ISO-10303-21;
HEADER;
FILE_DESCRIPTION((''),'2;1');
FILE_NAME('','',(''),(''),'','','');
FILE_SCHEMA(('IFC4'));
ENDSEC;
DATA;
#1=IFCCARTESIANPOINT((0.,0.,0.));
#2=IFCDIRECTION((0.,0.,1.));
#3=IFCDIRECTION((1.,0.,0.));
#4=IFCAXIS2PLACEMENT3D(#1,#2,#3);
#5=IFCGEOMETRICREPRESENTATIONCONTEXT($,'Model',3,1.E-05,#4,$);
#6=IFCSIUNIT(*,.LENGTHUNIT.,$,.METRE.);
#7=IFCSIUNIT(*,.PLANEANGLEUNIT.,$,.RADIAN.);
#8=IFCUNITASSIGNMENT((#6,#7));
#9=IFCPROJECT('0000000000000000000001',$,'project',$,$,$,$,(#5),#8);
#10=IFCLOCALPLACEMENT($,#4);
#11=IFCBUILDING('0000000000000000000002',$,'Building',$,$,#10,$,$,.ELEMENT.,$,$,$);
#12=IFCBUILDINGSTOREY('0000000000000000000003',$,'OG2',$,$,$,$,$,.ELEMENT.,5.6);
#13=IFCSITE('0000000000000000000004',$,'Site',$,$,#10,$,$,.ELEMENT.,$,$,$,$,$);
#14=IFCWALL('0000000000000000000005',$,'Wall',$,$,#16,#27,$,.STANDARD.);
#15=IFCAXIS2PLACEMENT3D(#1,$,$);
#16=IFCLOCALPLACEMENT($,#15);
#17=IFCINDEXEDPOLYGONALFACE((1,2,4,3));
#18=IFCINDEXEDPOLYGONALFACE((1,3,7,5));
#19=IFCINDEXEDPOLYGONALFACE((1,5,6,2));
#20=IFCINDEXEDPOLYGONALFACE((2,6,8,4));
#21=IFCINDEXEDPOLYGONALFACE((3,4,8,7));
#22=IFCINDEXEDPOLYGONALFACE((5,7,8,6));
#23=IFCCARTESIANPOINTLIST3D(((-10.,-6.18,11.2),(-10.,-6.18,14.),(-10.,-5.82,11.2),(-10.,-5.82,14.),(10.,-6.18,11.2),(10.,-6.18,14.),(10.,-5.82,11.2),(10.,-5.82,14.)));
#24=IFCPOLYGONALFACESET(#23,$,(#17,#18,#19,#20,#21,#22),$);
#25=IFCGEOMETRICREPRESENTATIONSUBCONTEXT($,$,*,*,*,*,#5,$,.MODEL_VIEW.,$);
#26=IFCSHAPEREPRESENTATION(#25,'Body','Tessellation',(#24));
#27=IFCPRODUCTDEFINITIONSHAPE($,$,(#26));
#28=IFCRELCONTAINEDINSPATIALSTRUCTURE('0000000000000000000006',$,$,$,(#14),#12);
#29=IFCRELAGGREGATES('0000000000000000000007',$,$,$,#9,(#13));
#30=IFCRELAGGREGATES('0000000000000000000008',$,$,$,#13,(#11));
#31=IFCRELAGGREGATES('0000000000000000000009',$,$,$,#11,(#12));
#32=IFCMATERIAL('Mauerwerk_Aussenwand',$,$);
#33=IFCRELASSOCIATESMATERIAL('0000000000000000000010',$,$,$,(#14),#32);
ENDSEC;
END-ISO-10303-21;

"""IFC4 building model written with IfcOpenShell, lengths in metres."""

from ifc_helpers import new_model, si_unit, frame, frame_2d, origin, origin_with_axes, place, context, subcontext, project, spatial, rectangle, extrude, material, element, save


model = new_model("IFC4")

# Units and contexts
model_context = context("Model", 3, precision=1e-05, world=origin_with_axes())
sub_context = subcontext(model_context, None, None, "MODEL_VIEW")
ifc_project = project(units=[si_unit("LENGTHUNIT", "METRE"), si_unit("PLANEANGLEUNIT", "RADIAN")], contexts=[model_context])

# Site, building, storey
placement_1 = place(None, origin_with_axes())
site = spatial("IfcSite", under=ifc_project, at=placement_1, Name="Site", CompositionType="ELEMENT")
building = spatial("IfcBuilding", under=site, at=placement_1, Name="Building", CompositionType="ELEMENT")
storey = spatial("IfcBuildingStorey", under=building, Name="OG2", CompositionType="ELEMENT", Elevation=5.6)

# Wall
ifc_material = material(Name="Mauerwerk_Aussenwand")
placement_2 = place(None, origin_with_axes())
placement_3 = place(placement_2, frame((0.0, 0.0, 5.6)))
wall_placement = place(placement_3, frame((-10.0, -6.0, 5.6), x_axis=(1.0, 0.0, 0.0)))
element("IfcWall", 1, at=wall_placement, inside=storey, material=ifc_material, Name="Wall", PredefinedType="STANDARD", context=sub_context, shape_type="SweptSolid", body=[
    extrude(rectangle(XDim=20.0, YDim=0.36, at=frame_2d((10.0, 0.0))), origin(), (0.0, 0.0, 1.0), 2.8),
])

save(model, "model.ifc")
